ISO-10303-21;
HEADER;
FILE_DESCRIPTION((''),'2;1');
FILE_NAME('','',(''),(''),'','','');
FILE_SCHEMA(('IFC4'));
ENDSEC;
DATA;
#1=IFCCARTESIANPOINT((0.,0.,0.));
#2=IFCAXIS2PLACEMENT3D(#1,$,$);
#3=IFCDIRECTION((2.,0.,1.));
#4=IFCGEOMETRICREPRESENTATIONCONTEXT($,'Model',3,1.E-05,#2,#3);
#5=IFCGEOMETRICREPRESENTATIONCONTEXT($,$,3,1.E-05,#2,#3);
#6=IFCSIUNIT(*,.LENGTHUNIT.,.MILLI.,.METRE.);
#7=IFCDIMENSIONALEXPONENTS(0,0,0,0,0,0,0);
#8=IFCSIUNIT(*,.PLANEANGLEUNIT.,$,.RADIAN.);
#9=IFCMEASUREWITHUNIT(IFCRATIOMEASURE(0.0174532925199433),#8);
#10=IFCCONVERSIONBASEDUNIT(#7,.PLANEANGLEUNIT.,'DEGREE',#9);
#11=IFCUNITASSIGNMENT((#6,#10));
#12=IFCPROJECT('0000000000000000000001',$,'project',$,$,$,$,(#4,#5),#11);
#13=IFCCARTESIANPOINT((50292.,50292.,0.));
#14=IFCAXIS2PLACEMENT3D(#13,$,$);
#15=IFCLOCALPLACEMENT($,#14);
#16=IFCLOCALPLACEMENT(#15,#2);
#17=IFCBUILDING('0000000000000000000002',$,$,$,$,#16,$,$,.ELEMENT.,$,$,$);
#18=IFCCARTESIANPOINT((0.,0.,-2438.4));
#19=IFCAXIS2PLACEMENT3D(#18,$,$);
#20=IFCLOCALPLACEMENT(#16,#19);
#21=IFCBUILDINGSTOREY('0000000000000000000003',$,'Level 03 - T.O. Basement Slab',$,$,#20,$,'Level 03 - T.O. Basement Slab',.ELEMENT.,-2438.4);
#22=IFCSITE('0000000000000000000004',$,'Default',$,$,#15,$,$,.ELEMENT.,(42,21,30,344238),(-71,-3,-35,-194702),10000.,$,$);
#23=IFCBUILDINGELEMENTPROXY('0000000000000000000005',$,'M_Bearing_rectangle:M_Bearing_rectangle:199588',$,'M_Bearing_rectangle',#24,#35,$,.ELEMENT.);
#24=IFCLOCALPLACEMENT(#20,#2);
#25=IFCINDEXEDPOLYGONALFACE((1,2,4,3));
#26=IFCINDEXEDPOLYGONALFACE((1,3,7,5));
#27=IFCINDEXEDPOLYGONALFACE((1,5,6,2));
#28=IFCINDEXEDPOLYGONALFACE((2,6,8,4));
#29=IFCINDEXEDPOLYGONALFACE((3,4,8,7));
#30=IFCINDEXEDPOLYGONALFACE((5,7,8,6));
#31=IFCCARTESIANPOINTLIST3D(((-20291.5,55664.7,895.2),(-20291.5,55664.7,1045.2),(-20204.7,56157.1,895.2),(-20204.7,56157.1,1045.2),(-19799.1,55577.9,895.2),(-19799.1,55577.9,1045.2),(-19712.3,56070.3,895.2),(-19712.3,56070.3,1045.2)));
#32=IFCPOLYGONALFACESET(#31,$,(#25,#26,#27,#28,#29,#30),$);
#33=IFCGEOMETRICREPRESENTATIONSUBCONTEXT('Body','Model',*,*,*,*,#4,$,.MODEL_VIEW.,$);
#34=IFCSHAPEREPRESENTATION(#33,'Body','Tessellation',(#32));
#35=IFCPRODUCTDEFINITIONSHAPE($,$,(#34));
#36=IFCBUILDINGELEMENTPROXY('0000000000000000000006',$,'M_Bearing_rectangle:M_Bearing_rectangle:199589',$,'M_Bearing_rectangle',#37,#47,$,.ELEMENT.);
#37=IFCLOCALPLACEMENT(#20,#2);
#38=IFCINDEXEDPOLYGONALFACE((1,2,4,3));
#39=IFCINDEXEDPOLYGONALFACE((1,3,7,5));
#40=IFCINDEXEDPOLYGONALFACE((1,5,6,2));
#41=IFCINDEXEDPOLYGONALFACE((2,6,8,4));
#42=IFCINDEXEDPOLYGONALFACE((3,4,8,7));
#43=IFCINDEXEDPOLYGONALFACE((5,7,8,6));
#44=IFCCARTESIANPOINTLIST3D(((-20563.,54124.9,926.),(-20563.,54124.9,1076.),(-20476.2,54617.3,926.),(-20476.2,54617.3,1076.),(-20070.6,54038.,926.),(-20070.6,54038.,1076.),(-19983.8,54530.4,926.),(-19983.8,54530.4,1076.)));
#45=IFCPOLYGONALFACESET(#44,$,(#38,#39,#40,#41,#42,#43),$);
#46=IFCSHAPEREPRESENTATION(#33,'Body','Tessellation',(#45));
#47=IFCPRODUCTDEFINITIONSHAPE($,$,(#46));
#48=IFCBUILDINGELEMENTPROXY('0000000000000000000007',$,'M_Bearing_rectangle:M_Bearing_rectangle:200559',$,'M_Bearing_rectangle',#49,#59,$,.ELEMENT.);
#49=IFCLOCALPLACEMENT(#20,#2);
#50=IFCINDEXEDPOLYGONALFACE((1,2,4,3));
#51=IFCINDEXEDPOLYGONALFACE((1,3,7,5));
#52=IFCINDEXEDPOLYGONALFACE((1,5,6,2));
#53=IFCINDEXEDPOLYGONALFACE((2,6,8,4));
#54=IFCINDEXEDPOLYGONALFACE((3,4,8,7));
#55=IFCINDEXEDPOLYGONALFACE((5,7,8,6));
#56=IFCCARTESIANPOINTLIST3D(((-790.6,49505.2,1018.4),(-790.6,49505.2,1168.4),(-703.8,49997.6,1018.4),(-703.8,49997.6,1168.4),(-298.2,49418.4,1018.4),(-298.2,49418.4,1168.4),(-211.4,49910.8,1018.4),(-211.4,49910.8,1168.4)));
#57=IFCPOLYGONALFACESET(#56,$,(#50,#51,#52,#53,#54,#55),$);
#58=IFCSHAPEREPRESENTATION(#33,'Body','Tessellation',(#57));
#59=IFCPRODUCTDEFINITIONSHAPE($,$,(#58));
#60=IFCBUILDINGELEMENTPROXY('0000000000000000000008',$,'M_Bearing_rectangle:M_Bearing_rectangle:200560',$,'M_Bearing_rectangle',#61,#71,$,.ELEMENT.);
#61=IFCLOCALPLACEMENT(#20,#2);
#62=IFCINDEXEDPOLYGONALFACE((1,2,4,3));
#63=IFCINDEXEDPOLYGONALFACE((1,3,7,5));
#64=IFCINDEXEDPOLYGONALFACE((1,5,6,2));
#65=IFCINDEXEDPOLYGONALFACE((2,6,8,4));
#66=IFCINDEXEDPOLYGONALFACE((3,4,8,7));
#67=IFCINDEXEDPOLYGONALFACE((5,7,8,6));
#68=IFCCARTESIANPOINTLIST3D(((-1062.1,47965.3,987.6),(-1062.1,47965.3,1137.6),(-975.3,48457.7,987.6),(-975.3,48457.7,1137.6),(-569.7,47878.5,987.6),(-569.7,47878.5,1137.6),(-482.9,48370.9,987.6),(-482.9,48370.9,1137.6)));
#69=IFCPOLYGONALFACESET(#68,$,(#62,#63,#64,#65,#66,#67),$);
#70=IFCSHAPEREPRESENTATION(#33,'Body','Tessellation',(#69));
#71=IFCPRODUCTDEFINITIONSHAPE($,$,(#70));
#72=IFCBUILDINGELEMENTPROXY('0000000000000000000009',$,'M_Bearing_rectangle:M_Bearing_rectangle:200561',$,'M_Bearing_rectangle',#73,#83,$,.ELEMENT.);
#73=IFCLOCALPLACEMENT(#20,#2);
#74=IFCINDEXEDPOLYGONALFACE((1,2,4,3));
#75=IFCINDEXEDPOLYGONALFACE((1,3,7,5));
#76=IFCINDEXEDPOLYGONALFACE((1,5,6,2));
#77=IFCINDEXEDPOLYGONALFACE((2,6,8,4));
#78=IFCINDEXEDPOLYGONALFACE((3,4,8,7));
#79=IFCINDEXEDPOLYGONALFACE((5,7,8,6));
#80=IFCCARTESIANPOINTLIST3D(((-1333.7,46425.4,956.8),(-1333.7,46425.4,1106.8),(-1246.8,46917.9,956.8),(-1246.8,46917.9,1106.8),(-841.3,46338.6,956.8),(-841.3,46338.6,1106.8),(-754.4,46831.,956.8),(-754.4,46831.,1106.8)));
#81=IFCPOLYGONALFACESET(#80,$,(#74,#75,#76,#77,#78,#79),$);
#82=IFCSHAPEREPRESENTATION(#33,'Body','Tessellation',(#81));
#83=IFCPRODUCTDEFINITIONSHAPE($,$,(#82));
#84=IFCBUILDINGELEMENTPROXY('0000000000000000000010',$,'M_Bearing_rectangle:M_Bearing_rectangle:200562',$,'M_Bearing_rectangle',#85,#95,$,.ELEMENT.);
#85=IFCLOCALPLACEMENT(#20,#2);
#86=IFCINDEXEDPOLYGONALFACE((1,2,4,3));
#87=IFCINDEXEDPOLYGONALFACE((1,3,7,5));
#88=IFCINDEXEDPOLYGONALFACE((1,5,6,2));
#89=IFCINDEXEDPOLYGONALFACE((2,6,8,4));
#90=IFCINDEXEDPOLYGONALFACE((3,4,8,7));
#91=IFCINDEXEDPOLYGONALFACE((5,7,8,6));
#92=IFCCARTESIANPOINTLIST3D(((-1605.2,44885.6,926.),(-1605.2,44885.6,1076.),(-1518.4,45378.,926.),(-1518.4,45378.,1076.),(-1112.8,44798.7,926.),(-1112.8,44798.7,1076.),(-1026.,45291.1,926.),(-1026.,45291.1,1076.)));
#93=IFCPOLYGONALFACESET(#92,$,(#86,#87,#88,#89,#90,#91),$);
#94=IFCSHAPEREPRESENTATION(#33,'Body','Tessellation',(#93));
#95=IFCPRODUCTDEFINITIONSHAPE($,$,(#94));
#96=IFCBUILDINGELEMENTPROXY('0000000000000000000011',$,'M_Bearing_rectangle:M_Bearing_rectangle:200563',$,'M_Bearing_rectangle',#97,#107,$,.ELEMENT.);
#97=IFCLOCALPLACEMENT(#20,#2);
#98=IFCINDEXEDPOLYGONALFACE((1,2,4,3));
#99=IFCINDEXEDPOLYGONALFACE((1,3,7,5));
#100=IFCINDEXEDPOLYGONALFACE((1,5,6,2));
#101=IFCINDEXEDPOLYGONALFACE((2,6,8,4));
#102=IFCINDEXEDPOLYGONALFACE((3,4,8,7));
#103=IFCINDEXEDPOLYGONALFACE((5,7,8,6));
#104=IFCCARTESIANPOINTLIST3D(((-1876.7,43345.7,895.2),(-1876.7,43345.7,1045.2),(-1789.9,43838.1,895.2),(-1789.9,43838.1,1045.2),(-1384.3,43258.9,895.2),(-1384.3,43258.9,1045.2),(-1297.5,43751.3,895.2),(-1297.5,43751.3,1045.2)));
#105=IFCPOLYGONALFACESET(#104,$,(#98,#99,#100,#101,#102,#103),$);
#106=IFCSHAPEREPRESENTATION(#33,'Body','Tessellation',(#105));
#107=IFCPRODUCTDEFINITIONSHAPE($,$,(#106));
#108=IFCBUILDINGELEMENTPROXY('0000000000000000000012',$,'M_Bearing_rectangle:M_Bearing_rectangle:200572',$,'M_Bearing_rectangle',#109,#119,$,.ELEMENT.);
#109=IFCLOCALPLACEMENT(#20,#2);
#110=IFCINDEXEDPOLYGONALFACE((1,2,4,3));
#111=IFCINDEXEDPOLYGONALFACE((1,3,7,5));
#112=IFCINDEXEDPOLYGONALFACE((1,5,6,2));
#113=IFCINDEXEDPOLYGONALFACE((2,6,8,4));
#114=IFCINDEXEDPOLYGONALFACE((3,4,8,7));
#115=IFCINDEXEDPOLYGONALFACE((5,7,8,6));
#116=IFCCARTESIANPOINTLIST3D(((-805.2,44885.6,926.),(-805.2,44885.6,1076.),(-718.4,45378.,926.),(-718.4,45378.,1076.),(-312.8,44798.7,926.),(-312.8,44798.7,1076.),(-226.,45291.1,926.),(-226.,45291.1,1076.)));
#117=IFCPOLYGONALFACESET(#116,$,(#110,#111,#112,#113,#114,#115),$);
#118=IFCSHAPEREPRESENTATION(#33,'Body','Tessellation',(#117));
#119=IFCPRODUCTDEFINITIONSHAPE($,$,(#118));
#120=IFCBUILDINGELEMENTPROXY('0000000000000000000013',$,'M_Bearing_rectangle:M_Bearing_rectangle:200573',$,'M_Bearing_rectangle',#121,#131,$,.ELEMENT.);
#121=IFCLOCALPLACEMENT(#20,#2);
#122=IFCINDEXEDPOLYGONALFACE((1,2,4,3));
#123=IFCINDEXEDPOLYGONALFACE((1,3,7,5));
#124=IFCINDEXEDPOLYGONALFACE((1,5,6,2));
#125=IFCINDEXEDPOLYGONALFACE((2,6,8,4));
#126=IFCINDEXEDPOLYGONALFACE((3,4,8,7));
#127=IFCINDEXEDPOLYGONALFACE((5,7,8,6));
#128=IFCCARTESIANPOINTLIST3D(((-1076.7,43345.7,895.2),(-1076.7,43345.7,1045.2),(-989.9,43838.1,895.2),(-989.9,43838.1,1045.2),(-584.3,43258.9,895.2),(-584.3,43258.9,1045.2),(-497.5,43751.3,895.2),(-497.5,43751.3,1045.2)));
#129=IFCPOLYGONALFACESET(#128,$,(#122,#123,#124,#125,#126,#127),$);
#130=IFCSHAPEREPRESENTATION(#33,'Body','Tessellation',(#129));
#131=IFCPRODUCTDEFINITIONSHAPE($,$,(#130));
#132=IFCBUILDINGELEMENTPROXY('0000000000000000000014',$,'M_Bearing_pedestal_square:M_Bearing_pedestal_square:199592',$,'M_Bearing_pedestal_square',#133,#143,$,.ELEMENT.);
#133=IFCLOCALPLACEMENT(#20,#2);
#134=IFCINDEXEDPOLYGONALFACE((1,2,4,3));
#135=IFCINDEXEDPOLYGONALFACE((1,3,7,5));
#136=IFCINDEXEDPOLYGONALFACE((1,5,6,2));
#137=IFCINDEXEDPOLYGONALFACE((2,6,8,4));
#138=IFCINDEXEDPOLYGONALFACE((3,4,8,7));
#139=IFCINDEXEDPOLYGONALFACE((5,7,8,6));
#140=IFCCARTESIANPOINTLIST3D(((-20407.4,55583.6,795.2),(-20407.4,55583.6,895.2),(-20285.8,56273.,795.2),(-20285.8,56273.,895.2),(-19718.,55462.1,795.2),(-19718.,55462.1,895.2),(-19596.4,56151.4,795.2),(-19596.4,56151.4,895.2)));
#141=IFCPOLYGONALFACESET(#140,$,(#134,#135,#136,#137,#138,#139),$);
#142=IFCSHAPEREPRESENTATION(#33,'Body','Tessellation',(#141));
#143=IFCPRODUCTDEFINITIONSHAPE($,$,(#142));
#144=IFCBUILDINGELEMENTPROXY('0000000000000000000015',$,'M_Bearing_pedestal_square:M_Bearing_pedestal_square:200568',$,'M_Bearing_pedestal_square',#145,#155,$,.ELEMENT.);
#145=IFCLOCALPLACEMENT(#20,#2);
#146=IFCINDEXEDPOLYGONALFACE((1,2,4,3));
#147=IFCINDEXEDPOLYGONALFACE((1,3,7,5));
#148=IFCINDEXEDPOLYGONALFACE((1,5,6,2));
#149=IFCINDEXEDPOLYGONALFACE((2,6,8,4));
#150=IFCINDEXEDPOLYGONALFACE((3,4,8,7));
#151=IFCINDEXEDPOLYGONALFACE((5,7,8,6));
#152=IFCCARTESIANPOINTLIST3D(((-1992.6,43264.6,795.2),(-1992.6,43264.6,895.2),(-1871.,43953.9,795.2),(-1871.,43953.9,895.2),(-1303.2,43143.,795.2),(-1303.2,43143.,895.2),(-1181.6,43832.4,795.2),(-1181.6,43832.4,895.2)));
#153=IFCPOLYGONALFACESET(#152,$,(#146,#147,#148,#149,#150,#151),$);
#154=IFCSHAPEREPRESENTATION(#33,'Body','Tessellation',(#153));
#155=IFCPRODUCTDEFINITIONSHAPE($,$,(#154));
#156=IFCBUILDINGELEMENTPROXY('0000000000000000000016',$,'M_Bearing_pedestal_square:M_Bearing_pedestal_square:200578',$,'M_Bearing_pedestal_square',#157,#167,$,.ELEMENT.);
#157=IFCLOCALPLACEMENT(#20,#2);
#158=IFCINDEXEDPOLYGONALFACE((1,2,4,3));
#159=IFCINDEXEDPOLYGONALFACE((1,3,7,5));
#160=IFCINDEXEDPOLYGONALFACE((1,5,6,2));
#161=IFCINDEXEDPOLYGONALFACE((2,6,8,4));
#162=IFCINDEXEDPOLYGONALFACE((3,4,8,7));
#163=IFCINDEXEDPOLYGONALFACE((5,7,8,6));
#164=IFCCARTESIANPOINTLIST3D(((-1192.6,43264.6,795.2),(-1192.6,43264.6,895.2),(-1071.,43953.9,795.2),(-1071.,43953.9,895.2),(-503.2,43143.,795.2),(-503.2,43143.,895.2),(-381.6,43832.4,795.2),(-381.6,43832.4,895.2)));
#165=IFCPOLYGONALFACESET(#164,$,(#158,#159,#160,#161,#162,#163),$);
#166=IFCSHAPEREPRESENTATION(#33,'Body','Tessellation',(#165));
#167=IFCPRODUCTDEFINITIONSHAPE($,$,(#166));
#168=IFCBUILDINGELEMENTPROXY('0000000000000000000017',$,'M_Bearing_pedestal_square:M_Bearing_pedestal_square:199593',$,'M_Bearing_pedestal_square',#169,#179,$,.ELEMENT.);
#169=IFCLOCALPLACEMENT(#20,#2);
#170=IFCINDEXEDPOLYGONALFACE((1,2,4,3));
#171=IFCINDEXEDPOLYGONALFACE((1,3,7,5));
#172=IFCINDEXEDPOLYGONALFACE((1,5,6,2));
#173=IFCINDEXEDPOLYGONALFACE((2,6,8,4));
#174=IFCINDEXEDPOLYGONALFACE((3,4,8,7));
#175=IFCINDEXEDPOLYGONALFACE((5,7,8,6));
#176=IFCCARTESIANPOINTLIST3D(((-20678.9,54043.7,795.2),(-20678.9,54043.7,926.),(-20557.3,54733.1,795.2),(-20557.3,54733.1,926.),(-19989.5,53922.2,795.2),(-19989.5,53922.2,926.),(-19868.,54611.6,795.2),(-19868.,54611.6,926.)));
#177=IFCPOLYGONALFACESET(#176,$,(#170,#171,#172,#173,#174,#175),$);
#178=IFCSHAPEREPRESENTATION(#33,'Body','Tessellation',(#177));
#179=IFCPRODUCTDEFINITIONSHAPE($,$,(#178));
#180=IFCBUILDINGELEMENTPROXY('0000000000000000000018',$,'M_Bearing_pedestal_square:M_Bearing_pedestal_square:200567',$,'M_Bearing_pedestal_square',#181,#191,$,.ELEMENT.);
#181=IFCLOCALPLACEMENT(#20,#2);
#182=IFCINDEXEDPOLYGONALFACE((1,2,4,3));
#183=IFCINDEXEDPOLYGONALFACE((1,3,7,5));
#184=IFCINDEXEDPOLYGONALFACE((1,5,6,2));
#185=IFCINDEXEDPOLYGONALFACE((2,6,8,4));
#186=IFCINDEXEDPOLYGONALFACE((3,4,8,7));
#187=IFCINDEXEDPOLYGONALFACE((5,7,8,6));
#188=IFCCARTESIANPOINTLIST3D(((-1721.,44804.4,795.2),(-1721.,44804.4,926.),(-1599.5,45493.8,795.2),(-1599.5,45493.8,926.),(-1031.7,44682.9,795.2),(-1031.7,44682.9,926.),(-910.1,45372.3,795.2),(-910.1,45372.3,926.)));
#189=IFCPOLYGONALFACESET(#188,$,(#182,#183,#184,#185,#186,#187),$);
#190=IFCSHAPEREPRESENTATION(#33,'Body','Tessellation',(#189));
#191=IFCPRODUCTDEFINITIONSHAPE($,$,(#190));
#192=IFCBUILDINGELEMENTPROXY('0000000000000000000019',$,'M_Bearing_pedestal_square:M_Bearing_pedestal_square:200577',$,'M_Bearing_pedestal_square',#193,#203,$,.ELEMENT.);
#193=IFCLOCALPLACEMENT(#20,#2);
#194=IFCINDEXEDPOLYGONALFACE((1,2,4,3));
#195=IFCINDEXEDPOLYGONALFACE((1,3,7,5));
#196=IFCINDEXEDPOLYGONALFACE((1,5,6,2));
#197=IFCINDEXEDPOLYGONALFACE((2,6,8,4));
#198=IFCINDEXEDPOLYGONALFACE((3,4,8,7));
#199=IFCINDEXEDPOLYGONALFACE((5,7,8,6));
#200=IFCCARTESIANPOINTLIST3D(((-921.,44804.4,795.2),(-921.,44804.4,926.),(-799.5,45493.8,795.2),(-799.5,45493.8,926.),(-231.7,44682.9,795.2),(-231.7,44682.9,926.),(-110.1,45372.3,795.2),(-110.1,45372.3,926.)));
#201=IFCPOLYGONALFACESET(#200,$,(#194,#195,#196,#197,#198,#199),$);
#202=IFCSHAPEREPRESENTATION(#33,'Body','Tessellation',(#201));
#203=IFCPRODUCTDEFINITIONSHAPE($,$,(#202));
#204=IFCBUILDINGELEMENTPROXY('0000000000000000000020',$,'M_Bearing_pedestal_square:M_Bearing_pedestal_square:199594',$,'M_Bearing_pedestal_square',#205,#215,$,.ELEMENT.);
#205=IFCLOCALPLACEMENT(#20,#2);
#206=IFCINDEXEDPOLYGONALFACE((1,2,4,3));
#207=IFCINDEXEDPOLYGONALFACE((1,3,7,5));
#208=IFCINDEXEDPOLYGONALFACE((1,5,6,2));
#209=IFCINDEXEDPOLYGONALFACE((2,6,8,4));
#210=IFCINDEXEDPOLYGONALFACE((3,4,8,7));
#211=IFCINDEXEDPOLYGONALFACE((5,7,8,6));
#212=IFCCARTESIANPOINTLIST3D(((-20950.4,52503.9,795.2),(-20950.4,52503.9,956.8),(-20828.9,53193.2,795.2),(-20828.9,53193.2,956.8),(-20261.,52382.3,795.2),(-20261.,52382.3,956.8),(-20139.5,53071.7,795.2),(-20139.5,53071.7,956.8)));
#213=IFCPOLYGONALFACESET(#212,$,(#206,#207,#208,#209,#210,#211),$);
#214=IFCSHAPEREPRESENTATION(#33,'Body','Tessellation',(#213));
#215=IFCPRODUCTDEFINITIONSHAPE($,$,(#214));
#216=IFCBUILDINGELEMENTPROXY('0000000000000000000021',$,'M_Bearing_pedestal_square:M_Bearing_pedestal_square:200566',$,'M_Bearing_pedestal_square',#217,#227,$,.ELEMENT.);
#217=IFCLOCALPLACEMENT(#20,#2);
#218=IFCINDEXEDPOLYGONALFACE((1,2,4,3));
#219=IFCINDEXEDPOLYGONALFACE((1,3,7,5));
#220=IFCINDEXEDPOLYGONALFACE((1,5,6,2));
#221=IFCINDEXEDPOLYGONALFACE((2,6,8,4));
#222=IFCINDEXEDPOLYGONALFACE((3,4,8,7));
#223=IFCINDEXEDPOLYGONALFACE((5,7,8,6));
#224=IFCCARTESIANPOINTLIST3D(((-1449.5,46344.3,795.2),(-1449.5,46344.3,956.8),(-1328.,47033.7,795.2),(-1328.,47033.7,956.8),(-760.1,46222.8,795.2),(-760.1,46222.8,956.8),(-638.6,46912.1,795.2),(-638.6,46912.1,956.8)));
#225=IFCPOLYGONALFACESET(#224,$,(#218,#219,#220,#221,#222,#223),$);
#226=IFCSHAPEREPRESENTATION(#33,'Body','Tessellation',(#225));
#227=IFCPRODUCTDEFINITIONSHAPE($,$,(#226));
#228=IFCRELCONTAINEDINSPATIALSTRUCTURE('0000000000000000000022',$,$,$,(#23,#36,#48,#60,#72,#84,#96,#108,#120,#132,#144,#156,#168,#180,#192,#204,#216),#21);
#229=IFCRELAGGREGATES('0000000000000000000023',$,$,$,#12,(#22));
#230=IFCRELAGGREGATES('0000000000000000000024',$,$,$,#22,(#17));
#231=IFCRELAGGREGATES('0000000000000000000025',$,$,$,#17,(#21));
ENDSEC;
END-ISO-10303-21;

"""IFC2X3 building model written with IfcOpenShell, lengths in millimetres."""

from ifc_helpers import new_model, entity, si_unit, converted_unit, direction, frame, origin, origin_2d_with_axis, place, context, subcontext, project, spatial, rectangle, extrude, source, transform, mapped, element, save


model = new_model("IFC2X3")

# Units and contexts
model_context = context("Model", 3, precision=1e-05, world=origin(), true_north=direction((2.0, 0.0, 1.0)))
context_of_model = context(None, 3, precision=1e-05, world=origin(), true_north=direction((2.0, 0.0, 1.0)))
body_context = subcontext(model_context, "Body", "Model", "MODEL_VIEW")
ifc_project = project(units=[si_unit("LENGTHUNIT", "METRE", prefix="MILLI"), converted_unit("PLANEANGLEUNIT", "DEGREE", entity("IfcRatioMeasure", 0.0174532925199433), si_unit("PLANEANGLEUNIT", "RADIAN"), dimensions=[0, 0, 0, 0, 0, 0, 0])], contexts=[model_context, context_of_model])

# Site, building, storey
site_placement = place(None, frame((50292.0, 50292.0, 0.0)))
site = spatial("IfcSite", under=ifc_project, at=site_placement, Name="Default", CompositionType="ELEMENT", RefLatitude=(42, 21, 30, 344238), RefLongitude=(-71, -3, -35, -194702), RefElevation=10000.0)
building_placement = place(site_placement, origin())
building = spatial("IfcBuilding", under=site, at=building_placement, CompositionType="ELEMENT")
storey_placement = place(building_placement, frame((0.0, 0.0, -2438.4)))
storey = spatial("IfcBuildingStorey", under=building, at=storey_placement, Name="Level 03 - T.O. Basement Slab", LongName="Level 03 - T.O. Basement Slab", CompositionType="ELEMENT", Elevation=-2438.4)

# Building element proxies
shared_shape_1 = source(origin(), body_context, "Body", "SweptSolid", [
    extrude(rectangle(XDim=500.0, YDim=500.0, at=origin_2d_with_axis()), frame((0.0, 0.0, -150.0), z_axis=(0.0, 0.0, 1.0), x_axis=(-1.0, 0.0, 0.0)), (0.0, 0.0, 1.0), 150.0),
])
for number, where, z_axis, x_axis, name in (
    (1, (-20001.9, 55867.5, 1045.2), (0.0, 0.0, 1.0), (0.173648, 0.984808, 0.0), "M_Bearing_rectangle:M_Bearing_rectangle:199588"),
    (2, (-20273.4, 54327.6, 1076.0), (0.0, 0.0, 1.0), (0.173648, 0.984808, 0.0), "M_Bearing_rectangle:M_Bearing_rectangle:199589"),
    (3, (-501.0, 49708.0, 1168.4), (0.0, 0.0, 1.0), (0.173648, 0.984808, 0.0), "M_Bearing_rectangle:M_Bearing_rectangle:200559"),
    (4, (-772.5, 48168.1, 1137.6), (0.0, 0.0, 1.0), (0.173648, 0.984808, 0.0), "M_Bearing_rectangle:M_Bearing_rectangle:200560"),
    (5, (-1044.0, 46628.2, 1106.8), (0.0, 0.0, 1.0), (0.173648, 0.984808, 0.0), "M_Bearing_rectangle:M_Bearing_rectangle:200561"),
    (6, (-1315.6, 45088.4, 1076.0), (0.0, 0.0, 1.0), (0.173648, 0.984808, 0.0), "M_Bearing_rectangle:M_Bearing_rectangle:200562"),
    (7, (-1587.1, 43548.5, 1045.2), (0.0, 0.0, 1.0), (0.173648, 0.984808, 0.0), "M_Bearing_rectangle:M_Bearing_rectangle:200563"),
    (8, (-515.6, 45088.4, 1076.0), (0.0, 0.0, 1.0), (0.173648, 0.984808, 0.0), "M_Bearing_rectangle:M_Bearing_rectangle:200572"),
    (9, (-787.1, 43548.5, 1045.2), (0.0, 0.0, 1.0), (0.173648, 0.984808, 0.0), "M_Bearing_rectangle:M_Bearing_rectangle:200573"),
):
    element("IfcBuildingElementProxy", number, at=place(storey_placement, frame(where, z_axis=z_axis, x_axis=x_axis)), inside=storey, Name=name, ObjectType="M_Bearing_rectangle", CompositionType="ELEMENT", context=body_context, shape_type="MappedRepresentation", body=[
        mapped(shared_shape_1, transform((0.0, 0.0, 0.0), scale=1.0)),
    ])
shared_shape_2 = source(origin(), body_context, "Body", "SweptSolid", [
    extrude(rectangle(XDim=700.0, YDim=700.0, at=origin_2d_with_axis()), frame((0.0, 0.0, -100.0)), (0.0, 0.0, 1.0), 100.0),
])
for number, where, z_axis, x_axis, name in (
    (10, (-20001.9, 55867.5, 895.2), (0.0, 0.0, 1.0), (0.173648, 0.984808, 0.0), "M_Bearing_pedestal_square:M_Bearing_pedestal_square:199592"),
    (11, (-1587.1, 43548.5, 895.2), (0.0, 0.0, 1.0), (0.173648, 0.984808, 0.0), "M_Bearing_pedestal_square:M_Bearing_pedestal_square:200568"),
    (12, (-787.1, 43548.5, 895.2), (0.0, 0.0, 1.0), (0.173648, 0.984808, 0.0), "M_Bearing_pedestal_square:M_Bearing_pedestal_square:200578"),
):
    element("IfcBuildingElementProxy", number, at=place(storey_placement, frame(where, z_axis=z_axis, x_axis=x_axis)), inside=storey, Name=name, ObjectType="M_Bearing_pedestal_square", CompositionType="ELEMENT", context=body_context, shape_type="MappedRepresentation", body=[
        mapped(shared_shape_2, transform((0.0, 0.0, 0.0), scale=1.0)),
    ])
shared_shape_3 = source(origin(), body_context, "Body", "SweptSolid", [
    extrude(rectangle(XDim=700.0, YDim=700.0, at=origin_2d_with_axis()), frame((0.0, 0.0, -130.8)), (0.0, 0.0, 1.0), 130.8),
])
for number, where, z_axis, x_axis, name in (
    (13, (-20273.4, 54327.6, 926.0), (0.0, 0.0, 1.0), (0.173648, 0.984808, 0.0), "M_Bearing_pedestal_square:M_Bearing_pedestal_square:199593"),
    (14, (-1315.6, 45088.4, 926.0), (0.0, 0.0, 1.0), (0.173648, 0.984808, 0.0), "M_Bearing_pedestal_square:M_Bearing_pedestal_square:200567"),
    (15, (-515.6, 45088.4, 926.0), (0.0, 0.0, 1.0), (0.173648, 0.984808, 0.0), "M_Bearing_pedestal_square:M_Bearing_pedestal_square:200577"),
):
    element("IfcBuildingElementProxy", number, at=place(storey_placement, frame(where, z_axis=z_axis, x_axis=x_axis)), inside=storey, Name=name, ObjectType="M_Bearing_pedestal_square", CompositionType="ELEMENT", context=body_context, shape_type="MappedRepresentation", body=[
        mapped(shared_shape_3, transform((0.0, 0.0, 0.0), scale=1.0)),
    ])
shared_shape_4 = source(origin(), body_context, "Body", "SweptSolid", [
    extrude(rectangle(XDim=700.0, YDim=700.0, at=origin_2d_with_axis()), frame((0.0, 0.0, -161.6)), (0.0, 0.0, 1.0), 161.6),
])
for number, where, z_axis, x_axis, name in (
    (16, (-20545.0, 52787.8, 956.8), (0.0, 0.0, 1.0), (0.173648, 0.984808, 0.0), "M_Bearing_pedestal_square:M_Bearing_pedestal_square:199594"),
    (17, (-1044.0, 46628.2, 956.8), (0.0, 0.0, 1.0), (0.173648, 0.984808, 0.0), "M_Bearing_pedestal_square:M_Bearing_pedestal_square:200566"),
):
    element("IfcBuildingElementProxy", number, at=place(storey_placement, frame(where, z_axis=z_axis, x_axis=x_axis)), inside=storey, Name=name, ObjectType="M_Bearing_pedestal_square", CompositionType="ELEMENT", context=body_context, shape_type="MappedRepresentation", body=[
        mapped(shared_shape_4, transform((0.0, 0.0, 0.0), scale=1.0)),
    ])

save(model, "model.ifc")
